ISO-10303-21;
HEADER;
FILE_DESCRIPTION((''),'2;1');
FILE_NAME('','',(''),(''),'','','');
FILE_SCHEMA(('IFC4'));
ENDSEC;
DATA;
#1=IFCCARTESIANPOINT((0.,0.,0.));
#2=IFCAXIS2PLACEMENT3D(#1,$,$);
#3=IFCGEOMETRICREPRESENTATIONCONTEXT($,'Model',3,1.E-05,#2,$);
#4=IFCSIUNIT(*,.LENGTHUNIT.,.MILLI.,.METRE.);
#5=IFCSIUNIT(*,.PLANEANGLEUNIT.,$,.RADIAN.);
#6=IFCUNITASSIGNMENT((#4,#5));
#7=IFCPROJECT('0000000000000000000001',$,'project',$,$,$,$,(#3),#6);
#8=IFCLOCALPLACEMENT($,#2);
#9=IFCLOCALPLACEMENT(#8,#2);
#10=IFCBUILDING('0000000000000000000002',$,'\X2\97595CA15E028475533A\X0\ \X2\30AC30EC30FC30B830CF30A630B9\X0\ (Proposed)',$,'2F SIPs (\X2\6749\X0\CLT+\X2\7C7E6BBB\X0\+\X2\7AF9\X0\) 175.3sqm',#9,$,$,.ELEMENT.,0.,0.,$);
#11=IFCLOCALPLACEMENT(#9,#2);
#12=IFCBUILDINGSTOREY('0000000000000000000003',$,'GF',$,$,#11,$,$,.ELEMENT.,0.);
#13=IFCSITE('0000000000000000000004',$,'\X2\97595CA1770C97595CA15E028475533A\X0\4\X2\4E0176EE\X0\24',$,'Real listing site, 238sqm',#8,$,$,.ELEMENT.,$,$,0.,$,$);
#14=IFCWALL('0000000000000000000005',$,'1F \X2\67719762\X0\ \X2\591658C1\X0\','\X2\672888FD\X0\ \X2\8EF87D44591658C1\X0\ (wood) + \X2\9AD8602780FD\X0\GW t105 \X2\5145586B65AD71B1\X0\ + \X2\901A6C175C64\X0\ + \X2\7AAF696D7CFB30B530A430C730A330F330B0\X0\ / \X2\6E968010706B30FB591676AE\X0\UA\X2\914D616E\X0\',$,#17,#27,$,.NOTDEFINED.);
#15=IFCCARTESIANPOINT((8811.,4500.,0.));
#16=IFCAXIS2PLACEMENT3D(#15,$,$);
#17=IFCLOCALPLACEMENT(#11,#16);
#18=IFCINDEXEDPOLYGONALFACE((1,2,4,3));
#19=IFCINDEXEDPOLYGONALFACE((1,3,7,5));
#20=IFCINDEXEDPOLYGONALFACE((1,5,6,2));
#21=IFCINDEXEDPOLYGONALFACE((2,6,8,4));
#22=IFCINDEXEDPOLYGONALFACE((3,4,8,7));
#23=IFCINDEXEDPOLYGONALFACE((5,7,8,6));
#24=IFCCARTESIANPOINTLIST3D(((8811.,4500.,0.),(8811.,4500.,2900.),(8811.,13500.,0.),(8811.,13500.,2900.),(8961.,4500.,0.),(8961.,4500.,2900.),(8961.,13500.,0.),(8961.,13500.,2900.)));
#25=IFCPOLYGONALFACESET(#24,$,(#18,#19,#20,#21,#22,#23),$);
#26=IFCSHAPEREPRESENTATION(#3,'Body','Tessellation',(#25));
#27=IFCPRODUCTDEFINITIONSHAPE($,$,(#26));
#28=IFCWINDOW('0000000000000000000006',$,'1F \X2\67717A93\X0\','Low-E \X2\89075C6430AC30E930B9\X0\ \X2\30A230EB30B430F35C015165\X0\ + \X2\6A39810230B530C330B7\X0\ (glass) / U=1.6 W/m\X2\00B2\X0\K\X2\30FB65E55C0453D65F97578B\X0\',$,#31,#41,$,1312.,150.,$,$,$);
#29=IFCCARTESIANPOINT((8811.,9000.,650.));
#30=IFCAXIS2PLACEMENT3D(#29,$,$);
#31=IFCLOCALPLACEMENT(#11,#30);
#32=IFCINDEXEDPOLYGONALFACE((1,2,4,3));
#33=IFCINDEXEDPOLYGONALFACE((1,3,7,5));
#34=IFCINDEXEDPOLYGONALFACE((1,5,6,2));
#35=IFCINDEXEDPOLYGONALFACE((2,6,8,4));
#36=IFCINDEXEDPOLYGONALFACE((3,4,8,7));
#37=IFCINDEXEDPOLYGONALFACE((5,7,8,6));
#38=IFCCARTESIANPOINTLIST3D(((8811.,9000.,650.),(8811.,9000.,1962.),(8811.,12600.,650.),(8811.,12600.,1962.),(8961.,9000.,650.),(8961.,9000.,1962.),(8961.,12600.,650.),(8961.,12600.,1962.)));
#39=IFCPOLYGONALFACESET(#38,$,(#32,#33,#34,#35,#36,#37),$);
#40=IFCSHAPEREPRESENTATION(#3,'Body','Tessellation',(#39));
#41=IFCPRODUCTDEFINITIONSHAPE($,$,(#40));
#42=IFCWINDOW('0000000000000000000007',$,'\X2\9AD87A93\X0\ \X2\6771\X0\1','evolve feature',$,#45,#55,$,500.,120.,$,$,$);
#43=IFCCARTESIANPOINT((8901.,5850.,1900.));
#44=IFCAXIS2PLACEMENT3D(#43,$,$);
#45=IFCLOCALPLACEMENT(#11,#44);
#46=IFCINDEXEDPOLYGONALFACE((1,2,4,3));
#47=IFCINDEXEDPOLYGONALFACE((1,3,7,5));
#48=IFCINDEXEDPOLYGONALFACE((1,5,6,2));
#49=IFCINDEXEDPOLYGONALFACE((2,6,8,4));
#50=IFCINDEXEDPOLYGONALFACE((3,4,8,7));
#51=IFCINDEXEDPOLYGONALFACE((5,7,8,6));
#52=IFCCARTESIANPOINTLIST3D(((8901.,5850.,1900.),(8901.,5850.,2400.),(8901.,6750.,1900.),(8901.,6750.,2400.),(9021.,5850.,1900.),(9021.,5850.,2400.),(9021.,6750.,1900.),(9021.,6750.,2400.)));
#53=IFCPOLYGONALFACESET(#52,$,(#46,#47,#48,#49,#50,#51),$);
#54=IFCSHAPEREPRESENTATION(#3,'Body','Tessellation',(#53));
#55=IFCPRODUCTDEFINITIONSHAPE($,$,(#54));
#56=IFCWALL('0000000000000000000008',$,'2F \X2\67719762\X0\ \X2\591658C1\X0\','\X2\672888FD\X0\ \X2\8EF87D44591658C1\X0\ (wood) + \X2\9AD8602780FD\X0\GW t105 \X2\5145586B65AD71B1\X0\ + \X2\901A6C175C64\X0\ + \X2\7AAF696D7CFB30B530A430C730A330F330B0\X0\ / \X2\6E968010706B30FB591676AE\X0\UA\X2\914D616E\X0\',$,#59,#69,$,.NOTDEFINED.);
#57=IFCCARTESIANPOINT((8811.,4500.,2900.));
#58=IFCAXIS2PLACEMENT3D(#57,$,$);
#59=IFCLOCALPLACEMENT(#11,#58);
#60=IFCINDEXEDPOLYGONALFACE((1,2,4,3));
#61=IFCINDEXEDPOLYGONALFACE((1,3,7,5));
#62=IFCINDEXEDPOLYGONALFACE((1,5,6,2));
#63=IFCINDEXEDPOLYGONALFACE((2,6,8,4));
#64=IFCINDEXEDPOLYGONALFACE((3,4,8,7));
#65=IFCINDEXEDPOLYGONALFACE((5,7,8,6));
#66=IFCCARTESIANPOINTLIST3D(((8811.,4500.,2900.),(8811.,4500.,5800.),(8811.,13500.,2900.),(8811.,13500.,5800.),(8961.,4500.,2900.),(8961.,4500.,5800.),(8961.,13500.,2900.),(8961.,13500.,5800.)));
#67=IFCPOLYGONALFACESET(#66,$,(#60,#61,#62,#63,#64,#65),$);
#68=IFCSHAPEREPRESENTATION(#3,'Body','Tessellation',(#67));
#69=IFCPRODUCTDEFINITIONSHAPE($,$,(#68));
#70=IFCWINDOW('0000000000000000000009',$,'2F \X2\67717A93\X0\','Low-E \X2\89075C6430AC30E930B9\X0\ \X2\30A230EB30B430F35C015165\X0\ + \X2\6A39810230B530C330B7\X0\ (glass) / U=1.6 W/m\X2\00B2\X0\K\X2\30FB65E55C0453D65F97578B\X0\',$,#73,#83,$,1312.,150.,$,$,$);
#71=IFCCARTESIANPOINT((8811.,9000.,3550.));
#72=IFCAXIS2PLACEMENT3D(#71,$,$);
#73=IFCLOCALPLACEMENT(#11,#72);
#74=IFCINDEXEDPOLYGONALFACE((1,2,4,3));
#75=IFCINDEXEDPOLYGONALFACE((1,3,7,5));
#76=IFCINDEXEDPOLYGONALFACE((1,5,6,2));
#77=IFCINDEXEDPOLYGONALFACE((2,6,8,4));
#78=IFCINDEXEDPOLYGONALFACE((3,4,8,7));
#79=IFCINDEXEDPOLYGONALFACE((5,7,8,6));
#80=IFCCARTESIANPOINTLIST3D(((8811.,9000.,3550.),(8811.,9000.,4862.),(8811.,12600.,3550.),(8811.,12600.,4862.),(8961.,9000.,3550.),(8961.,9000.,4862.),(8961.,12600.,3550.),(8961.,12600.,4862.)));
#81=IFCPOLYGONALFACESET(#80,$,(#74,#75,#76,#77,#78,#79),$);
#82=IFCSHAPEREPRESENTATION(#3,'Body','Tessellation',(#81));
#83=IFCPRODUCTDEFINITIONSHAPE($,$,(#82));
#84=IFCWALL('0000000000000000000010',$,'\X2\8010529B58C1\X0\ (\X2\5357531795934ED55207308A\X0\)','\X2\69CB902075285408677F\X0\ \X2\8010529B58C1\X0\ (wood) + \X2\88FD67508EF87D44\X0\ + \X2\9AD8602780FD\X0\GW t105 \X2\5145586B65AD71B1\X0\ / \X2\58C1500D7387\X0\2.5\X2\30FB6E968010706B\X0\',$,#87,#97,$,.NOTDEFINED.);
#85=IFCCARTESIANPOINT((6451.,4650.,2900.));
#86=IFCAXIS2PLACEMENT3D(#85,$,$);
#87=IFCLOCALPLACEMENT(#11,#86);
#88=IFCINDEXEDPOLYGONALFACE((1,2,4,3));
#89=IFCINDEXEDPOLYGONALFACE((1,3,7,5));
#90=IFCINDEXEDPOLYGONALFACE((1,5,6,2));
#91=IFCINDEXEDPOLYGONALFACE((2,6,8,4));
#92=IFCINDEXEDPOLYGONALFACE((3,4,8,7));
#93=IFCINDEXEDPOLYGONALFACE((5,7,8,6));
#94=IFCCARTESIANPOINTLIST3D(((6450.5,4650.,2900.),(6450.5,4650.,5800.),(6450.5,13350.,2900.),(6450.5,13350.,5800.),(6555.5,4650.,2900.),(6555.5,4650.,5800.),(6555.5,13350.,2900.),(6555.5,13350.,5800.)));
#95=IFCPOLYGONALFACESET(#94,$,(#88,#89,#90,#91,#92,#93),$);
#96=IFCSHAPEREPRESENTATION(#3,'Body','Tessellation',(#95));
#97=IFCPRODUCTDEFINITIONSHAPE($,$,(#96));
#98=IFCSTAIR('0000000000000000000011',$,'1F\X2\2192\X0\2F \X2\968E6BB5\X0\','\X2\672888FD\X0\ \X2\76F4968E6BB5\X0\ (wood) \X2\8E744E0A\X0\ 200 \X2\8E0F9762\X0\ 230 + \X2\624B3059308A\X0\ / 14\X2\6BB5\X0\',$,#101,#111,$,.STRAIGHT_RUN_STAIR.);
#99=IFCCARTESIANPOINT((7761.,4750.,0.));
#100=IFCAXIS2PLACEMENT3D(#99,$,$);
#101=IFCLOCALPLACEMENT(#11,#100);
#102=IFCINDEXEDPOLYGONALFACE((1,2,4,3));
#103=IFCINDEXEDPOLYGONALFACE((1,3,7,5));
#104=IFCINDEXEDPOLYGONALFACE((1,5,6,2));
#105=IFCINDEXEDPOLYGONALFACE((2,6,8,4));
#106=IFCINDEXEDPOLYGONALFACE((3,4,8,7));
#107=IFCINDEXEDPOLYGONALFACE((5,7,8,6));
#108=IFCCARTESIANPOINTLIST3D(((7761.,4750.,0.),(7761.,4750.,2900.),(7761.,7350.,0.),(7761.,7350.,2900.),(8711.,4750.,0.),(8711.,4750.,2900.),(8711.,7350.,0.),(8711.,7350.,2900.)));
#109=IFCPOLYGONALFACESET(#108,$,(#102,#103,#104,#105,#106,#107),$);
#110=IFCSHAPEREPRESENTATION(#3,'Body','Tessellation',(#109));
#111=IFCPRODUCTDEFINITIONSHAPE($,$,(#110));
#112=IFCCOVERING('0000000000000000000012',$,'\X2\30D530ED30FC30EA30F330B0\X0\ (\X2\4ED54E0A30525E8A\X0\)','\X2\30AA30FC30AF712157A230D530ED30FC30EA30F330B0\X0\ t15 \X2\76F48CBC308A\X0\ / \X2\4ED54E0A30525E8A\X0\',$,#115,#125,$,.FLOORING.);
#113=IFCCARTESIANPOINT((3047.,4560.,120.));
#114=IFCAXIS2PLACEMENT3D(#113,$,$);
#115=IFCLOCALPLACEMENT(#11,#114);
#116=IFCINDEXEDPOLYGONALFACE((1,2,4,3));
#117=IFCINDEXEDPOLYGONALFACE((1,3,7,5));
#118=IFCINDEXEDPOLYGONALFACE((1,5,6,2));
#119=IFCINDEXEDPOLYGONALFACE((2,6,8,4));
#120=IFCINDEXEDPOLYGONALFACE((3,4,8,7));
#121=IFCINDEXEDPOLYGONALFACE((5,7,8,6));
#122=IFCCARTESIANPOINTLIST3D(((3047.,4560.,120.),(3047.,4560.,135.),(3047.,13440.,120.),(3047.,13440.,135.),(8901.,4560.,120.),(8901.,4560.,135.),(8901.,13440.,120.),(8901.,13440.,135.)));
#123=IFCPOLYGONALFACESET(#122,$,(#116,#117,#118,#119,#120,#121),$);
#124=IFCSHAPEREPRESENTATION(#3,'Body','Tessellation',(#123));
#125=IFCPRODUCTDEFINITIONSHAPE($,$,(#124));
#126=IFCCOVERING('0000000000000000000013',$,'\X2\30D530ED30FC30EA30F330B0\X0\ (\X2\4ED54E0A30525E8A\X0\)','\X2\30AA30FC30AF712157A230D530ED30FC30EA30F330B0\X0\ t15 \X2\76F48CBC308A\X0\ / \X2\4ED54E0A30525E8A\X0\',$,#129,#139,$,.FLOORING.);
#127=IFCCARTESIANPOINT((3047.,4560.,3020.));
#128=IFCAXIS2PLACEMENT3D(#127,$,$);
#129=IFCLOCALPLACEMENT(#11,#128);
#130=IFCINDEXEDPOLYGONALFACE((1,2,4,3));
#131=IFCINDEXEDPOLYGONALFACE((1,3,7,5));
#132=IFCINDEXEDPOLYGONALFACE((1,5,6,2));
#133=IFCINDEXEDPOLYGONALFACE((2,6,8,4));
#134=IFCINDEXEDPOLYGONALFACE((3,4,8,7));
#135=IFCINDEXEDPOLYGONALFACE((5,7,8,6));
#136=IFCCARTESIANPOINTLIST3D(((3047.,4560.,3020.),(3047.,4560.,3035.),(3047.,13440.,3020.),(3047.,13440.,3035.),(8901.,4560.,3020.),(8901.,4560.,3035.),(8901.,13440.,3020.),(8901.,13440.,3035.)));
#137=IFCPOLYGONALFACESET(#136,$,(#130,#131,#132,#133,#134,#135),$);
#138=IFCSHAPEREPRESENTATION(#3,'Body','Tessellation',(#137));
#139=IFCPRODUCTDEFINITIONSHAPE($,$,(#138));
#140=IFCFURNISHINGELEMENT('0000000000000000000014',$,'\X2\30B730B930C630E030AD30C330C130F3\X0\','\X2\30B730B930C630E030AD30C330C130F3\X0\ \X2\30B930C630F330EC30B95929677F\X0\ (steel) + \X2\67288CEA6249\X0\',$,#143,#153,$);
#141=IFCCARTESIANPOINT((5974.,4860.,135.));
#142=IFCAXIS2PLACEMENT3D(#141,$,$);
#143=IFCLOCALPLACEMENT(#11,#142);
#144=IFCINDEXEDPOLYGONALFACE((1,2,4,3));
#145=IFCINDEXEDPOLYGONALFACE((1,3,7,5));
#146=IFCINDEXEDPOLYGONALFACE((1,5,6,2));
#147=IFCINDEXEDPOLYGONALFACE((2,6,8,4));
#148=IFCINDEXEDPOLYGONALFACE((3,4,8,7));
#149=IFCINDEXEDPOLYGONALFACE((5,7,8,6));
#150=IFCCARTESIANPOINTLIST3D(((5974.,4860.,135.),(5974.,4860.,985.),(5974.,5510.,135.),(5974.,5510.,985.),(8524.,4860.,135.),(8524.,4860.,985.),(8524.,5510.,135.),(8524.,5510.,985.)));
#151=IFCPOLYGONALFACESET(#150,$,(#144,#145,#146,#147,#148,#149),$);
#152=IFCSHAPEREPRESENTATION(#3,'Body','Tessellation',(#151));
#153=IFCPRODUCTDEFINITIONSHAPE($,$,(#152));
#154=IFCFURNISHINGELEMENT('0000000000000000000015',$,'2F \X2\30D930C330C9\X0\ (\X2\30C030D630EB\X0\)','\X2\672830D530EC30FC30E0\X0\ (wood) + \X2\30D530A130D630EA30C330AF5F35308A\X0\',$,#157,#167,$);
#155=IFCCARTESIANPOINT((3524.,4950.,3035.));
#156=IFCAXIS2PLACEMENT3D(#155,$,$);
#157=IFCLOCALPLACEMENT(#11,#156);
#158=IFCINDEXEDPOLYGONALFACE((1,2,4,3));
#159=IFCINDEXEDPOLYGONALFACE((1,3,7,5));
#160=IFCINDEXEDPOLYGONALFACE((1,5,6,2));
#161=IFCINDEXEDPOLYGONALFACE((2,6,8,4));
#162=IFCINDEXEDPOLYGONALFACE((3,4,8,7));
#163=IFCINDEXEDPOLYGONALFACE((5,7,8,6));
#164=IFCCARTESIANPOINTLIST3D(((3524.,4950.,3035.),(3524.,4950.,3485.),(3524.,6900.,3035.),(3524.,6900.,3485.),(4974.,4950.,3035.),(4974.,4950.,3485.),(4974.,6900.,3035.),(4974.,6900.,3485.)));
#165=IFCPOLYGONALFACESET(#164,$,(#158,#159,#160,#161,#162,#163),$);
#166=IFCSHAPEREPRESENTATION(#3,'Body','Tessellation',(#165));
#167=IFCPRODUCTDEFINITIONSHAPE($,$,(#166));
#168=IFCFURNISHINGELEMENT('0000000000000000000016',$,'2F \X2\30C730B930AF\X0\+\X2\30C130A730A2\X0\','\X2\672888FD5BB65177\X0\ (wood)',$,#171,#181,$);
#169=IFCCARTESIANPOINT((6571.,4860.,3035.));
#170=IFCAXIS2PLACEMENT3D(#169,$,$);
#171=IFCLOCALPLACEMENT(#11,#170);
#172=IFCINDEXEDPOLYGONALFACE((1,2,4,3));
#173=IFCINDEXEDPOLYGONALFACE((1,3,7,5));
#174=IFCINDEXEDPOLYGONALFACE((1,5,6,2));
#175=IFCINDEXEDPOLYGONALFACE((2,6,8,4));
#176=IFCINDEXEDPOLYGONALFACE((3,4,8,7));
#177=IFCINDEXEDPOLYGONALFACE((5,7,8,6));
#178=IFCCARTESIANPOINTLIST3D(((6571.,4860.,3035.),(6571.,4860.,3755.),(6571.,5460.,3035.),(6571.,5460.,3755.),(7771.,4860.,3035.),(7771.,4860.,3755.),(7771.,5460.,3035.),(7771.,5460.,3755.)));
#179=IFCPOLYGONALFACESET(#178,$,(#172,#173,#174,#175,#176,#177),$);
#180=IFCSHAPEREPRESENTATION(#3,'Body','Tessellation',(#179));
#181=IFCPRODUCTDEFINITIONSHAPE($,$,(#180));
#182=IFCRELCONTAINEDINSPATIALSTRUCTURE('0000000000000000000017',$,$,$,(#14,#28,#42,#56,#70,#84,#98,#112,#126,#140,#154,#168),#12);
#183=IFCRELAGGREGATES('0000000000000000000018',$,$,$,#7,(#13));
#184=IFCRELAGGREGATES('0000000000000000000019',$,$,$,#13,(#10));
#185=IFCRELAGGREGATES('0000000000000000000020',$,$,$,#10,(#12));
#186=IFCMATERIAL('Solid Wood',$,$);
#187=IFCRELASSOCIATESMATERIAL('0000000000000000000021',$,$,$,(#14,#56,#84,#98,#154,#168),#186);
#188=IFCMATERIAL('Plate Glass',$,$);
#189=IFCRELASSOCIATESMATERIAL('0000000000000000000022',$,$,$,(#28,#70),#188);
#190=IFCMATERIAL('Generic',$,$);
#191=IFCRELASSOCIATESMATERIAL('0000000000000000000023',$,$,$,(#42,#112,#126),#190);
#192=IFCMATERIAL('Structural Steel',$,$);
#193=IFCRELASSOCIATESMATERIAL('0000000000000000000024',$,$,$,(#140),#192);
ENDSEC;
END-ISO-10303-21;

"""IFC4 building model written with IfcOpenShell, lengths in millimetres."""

from ifc_helpers import new_model, si_unit, frame, frame_2d, origin, place, context, project, spatial, rectangle, extrude, material, element, fill, save


model = new_model("IFC4")

# Units and contexts
model_context = context("Model", 3, precision=1e-05, world=origin())
ifc_project = project(units=[si_unit("LENGTHUNIT", "METRE", prefix="MILLI"), si_unit("PLANEANGLEUNIT", "RADIAN")], contexts=[model_context])

# Site, building, storey
site_placement = place(None, origin())
site = spatial("IfcSite", under=ifc_project, at=site_placement, Name="静岡県静岡市葵区4丁目24", ObjectType="Real listing site, 238sqm", CompositionType="ELEMENT", RefElevation=0.0)
building_placement = place(site_placement, origin())
building = spatial("IfcBuilding", under=site, at=building_placement, Name="静岡市葵区 ガレージハウス (Proposed)", ObjectType="2F SIPs (杉CLT+籾殻+竹) 175.3sqm", CompositionType="ELEMENT", ElevationOfRefHeight=0.0, ElevationOfTerrain=0.0)
storey_placement = place(building_placement, origin())
storey = spatial("IfcBuildingStorey", under=building, at=storey_placement, Name="GF", CompositionType="ELEMENT", Elevation=0.0)

# Shared definitions
ifc_material_1 = material(Name="Solid Wood")

# Wall, openings, windows
wall_1_placement = place(storey_placement, frame((8811.0, 4500.0, 0.0)))
wall_1 = element("IfcWall", 1, at=wall_1_placement, inside=storey, material=ifc_material_1, Name="1F 東面 外壁", Description="木製 軸組外壁 (wood) + 高性能GW t105 充填断熱 + 通気層 + 窯業系サイディング / 準耐火・外皮UA配慮", PredefinedType="NOTDEFINED", context=model_context, shape_type="SweptSolid", body=[
    extrude(rectangle(XDim=150.0, YDim=9000.0, at=frame_2d((75.0, 4500.0))), frame((8811.0, 4500.0, 0.0)), (0.0, 0.0, 1.0), 2900.0),
])
opening_1_placement = place(storey_placement, frame((8811.0, 9000.0, 650.0)))
opening_1 = element("IfcOpeningElement", 2, at=opening_1_placement, cuts=wall_1, PredefinedType="NOTDEFINED", context=model_context, shape_type="SweptSolid", body=[
    extrude(rectangle(XDim=150.0, YDim=3600.0, at=frame_2d((75.0, 1800.0))), frame((8811.0, 9000.0, 650.0)), (0.0, 0.0, 1.0), 1312.0),
])
opening_2_placement = place(storey_placement, frame((8901.0, 5850.0, 1900.0)))
opening_2 = element("IfcOpeningElement", 3, at=opening_2_placement, cuts=wall_1, PredefinedType="NOTDEFINED", context=model_context, shape_type="SweptSolid", body=[
    extrude(rectangle(XDim=120.0, YDim=900.0, at=frame_2d((60.0, 450.0))), frame((8901.0, 5850.0, 1900.0)), (0.0, 0.0, 1.0), 500.0),
])
ifc_material_2 = material(Name="Plate Glass")
window_1_placement = place(storey_placement, frame((8811.0, 9000.0, 650.0)))
window_1 = element("IfcWindow", 4, at=window_1_placement, inside=storey, material=ifc_material_2, Name="1F 東窓", Description="Low-E 複層ガラス アルゴン封入 + 樹脂サッシ (glass) / U=1.6 W/m²K・日射取得型", OverallHeight=1312.0, OverallWidth=150.0, context=model_context, shape_type="SweptSolid", body=[
    extrude(rectangle(XDim=150.0, YDim=3600.0, at=frame_2d((75.0, 1800.0))), frame((8811.0, 9000.0, 650.0)), (0.0, 0.0, 1.0), 1312.0),
])
fill(opening_1, window_1)
ifc_material_3 = material(Name="Generic")
window_2_placement = place(storey_placement, frame((8901.0, 5850.0, 1900.0)))
window_2 = element("IfcWindow", 5, at=window_2_placement, inside=storey, material=ifc_material_3, Name="高窓 東1", Description="evolve feature", OverallHeight=500.0, OverallWidth=120.0, context=model_context, shape_type="SweptSolid", body=[
    extrude(rectangle(XDim=120.0, YDim=900.0, at=frame_2d((60.0, 450.0))), frame((8901.0, 5850.0, 1900.0)), (0.0, 0.0, 1.0), 500.0),
])
fill(opening_2, window_2)

# Wall, opening, window
wall_2_placement = place(storey_placement, frame((8811.0, 4500.0, 2900.0)))
wall_2 = element("IfcWall", 6, at=wall_2_placement, inside=storey, material=ifc_material_1, Name="2F 東面 外壁", Description="木製 軸組外壁 (wood) + 高性能GW t105 充填断熱 + 通気層 + 窯業系サイディング / 準耐火・外皮UA配慮", PredefinedType="NOTDEFINED", context=model_context, shape_type="SweptSolid", body=[
    extrude(rectangle(XDim=150.0, YDim=9000.0, at=frame_2d((75.0, 4500.0))), frame((8811.0, 4500.0, 2900.0)), (0.0, 0.0, 1.0), 2900.0),
])
opening_3_placement = place(storey_placement, frame((8811.0, 9000.0, 3550.0)))
opening_3 = element("IfcOpeningElement", 7, at=opening_3_placement, cuts=wall_2, PredefinedType="NOTDEFINED", context=model_context, shape_type="SweptSolid", body=[
    extrude(rectangle(XDim=150.0, YDim=3600.0, at=frame_2d((75.0, 1800.0))), frame((8811.0, 9000.0, 3550.0)), (0.0, 0.0, 1.0), 1312.0),
])
window_3_placement = place(storey_placement, frame((8811.0, 9000.0, 3550.0)))
window_3 = element("IfcWindow", 8, at=window_3_placement, inside=storey, material=ifc_material_2, Name="2F 東窓", Description="Low-E 複層ガラス アルゴン封入 + 樹脂サッシ (glass) / U=1.6 W/m²K・日射取得型", OverallHeight=1312.0, OverallWidth=150.0, context=model_context, shape_type="SweptSolid", body=[
    extrude(rectangle(XDim=150.0, YDim=3600.0, at=frame_2d((75.0, 1800.0))), frame((8811.0, 9000.0, 3550.0)), (0.0, 0.0, 1.0), 1312.0),
])
fill(opening_3, window_3)

# Wall
wall_3_placement = place(storey_placement, frame((6451.0, 4650.0, 2900.0)))
element("IfcWall", 9, at=wall_3_placement, inside=storey, material=ifc_material_1, Name="耐力壁 (南北間仕切り)", Description="構造用合板 耐力壁 (wood) + 製材軸組 + 高性能GW t105 充填断熱 / 壁倍率2.5・準耐火", PredefinedType="NOTDEFINED", context=model_context, shape_type="SweptSolid", body=[
    extrude(rectangle(XDim=105.0, YDim=8700.0, at=frame_2d((52.0, 4350.0))), frame((6451.0, 4650.0, 2900.0)), (0.0, 0.0, 1.0), 2900.0),
])

# Stair
stair_placement = place(storey_placement, frame((7761.0, 4750.0, 0.0)))
element("IfcStair", 10, at=stair_placement, inside=storey, material=ifc_material_1, Name="1F→2F 階段", Description="木製 直階段 (wood) 蹴上 200 踏面 230 + 手すり / 14段", PredefinedType="STRAIGHT_RUN_STAIR", context=model_context, shape_type="SweptSolid", body=[
    extrude(rectangle(XDim=950.0, YDim=2600.0, at=frame_2d((475.0, 1300.0))), frame((7761.0, 4750.0, 0.0)), (0.0, 0.0, 1.0), 2900.0),
])

# Coverings
covering_1_placement = place(storey_placement, frame((3047.0, 4560.0, 120.0)))
element("IfcCovering", 11, at=covering_1_placement, inside=storey, material=ifc_material_3, Name="フローリング (仕上げ床)", Description="オーク無垢フローリング t15 直貼り / 仕上げ床", PredefinedType="FLOORING", context=model_context, shape_type="SweptSolid", body=[
    extrude(rectangle(XDim=5854.0, YDim=8880.0, at=frame_2d((2927.0, 4440.0))), frame((3047.0, 4560.0, 120.0)), (0.0, 0.0, 1.0), 15.0),
])
covering_2_placement = place(storey_placement, frame((3047.0, 4560.0, 3020.0)))
element("IfcCovering", 12, at=covering_2_placement, inside=storey, material=ifc_material_3, Name="フローリング (仕上げ床)", Description="オーク無垢フローリング t15 直貼り / 仕上げ床", PredefinedType="FLOORING", context=model_context, shape_type="SweptSolid", body=[
    extrude(rectangle(XDim=5854.0, YDim=8880.0, at=frame_2d((2927.0, 4440.0))), frame((3047.0, 4560.0, 3020.0)), (0.0, 0.0, 1.0), 15.0),
])

# Furnishing elements
ifc_material_4 = material(Name="Structural Steel")
furnishing_1_placement = place(storey_placement, frame((5974.0, 4860.0, 135.0)))
element("IfcFurnishingElement", 13, at=furnishing_1_placement, inside=storey, material=ifc_material_4, Name="システムキッチン", Description="システムキッチン ステンレス天板 (steel) + 木質扉", context=model_context, shape_type="SweptSolid", body=[
    extrude(rectangle(XDim=2550.0, YDim=650.0, at=frame_2d((1275.0, 325.0))), frame((5974.0, 4860.0, 135.0)), (0.0, 0.0, 1.0), 850.0),
])
furnishing_2_placement = place(storey_placement, frame((3524.0, 4950.0, 3035.0)))
element("IfcFurnishingElement", 14, at=furnishing_2_placement, inside=storey, material=ifc_material_1, Name="2F ベッド (ダブル)", Description="木フレーム (wood) + ファブリック張り", context=model_context, shape_type="SweptSolid", body=[
    extrude(rectangle(XDim=1450.0, YDim=1950.0, at=frame_2d((725.0, 975.0))), frame((3524.0, 4950.0, 3035.0)), (0.0, 0.0, 1.0), 450.0),
])
furnishing_3_placement = place(storey_placement, frame((6571.0, 4860.0, 3035.0)))
element("IfcFurnishingElement", 15, at=furnishing_3_placement, inside=storey, material=ifc_material_1, Name="2F デスク+チェア", Description="木製家具 (wood)", context=model_context, shape_type="SweptSolid", body=[
    extrude(rectangle(XDim=1200.0, YDim=600.0, at=frame_2d((600.0, 300.0))), frame((6571.0, 4860.0, 3035.0)), (0.0, 0.0, 1.0), 720.0),
])

save(model, "model.ifc")
